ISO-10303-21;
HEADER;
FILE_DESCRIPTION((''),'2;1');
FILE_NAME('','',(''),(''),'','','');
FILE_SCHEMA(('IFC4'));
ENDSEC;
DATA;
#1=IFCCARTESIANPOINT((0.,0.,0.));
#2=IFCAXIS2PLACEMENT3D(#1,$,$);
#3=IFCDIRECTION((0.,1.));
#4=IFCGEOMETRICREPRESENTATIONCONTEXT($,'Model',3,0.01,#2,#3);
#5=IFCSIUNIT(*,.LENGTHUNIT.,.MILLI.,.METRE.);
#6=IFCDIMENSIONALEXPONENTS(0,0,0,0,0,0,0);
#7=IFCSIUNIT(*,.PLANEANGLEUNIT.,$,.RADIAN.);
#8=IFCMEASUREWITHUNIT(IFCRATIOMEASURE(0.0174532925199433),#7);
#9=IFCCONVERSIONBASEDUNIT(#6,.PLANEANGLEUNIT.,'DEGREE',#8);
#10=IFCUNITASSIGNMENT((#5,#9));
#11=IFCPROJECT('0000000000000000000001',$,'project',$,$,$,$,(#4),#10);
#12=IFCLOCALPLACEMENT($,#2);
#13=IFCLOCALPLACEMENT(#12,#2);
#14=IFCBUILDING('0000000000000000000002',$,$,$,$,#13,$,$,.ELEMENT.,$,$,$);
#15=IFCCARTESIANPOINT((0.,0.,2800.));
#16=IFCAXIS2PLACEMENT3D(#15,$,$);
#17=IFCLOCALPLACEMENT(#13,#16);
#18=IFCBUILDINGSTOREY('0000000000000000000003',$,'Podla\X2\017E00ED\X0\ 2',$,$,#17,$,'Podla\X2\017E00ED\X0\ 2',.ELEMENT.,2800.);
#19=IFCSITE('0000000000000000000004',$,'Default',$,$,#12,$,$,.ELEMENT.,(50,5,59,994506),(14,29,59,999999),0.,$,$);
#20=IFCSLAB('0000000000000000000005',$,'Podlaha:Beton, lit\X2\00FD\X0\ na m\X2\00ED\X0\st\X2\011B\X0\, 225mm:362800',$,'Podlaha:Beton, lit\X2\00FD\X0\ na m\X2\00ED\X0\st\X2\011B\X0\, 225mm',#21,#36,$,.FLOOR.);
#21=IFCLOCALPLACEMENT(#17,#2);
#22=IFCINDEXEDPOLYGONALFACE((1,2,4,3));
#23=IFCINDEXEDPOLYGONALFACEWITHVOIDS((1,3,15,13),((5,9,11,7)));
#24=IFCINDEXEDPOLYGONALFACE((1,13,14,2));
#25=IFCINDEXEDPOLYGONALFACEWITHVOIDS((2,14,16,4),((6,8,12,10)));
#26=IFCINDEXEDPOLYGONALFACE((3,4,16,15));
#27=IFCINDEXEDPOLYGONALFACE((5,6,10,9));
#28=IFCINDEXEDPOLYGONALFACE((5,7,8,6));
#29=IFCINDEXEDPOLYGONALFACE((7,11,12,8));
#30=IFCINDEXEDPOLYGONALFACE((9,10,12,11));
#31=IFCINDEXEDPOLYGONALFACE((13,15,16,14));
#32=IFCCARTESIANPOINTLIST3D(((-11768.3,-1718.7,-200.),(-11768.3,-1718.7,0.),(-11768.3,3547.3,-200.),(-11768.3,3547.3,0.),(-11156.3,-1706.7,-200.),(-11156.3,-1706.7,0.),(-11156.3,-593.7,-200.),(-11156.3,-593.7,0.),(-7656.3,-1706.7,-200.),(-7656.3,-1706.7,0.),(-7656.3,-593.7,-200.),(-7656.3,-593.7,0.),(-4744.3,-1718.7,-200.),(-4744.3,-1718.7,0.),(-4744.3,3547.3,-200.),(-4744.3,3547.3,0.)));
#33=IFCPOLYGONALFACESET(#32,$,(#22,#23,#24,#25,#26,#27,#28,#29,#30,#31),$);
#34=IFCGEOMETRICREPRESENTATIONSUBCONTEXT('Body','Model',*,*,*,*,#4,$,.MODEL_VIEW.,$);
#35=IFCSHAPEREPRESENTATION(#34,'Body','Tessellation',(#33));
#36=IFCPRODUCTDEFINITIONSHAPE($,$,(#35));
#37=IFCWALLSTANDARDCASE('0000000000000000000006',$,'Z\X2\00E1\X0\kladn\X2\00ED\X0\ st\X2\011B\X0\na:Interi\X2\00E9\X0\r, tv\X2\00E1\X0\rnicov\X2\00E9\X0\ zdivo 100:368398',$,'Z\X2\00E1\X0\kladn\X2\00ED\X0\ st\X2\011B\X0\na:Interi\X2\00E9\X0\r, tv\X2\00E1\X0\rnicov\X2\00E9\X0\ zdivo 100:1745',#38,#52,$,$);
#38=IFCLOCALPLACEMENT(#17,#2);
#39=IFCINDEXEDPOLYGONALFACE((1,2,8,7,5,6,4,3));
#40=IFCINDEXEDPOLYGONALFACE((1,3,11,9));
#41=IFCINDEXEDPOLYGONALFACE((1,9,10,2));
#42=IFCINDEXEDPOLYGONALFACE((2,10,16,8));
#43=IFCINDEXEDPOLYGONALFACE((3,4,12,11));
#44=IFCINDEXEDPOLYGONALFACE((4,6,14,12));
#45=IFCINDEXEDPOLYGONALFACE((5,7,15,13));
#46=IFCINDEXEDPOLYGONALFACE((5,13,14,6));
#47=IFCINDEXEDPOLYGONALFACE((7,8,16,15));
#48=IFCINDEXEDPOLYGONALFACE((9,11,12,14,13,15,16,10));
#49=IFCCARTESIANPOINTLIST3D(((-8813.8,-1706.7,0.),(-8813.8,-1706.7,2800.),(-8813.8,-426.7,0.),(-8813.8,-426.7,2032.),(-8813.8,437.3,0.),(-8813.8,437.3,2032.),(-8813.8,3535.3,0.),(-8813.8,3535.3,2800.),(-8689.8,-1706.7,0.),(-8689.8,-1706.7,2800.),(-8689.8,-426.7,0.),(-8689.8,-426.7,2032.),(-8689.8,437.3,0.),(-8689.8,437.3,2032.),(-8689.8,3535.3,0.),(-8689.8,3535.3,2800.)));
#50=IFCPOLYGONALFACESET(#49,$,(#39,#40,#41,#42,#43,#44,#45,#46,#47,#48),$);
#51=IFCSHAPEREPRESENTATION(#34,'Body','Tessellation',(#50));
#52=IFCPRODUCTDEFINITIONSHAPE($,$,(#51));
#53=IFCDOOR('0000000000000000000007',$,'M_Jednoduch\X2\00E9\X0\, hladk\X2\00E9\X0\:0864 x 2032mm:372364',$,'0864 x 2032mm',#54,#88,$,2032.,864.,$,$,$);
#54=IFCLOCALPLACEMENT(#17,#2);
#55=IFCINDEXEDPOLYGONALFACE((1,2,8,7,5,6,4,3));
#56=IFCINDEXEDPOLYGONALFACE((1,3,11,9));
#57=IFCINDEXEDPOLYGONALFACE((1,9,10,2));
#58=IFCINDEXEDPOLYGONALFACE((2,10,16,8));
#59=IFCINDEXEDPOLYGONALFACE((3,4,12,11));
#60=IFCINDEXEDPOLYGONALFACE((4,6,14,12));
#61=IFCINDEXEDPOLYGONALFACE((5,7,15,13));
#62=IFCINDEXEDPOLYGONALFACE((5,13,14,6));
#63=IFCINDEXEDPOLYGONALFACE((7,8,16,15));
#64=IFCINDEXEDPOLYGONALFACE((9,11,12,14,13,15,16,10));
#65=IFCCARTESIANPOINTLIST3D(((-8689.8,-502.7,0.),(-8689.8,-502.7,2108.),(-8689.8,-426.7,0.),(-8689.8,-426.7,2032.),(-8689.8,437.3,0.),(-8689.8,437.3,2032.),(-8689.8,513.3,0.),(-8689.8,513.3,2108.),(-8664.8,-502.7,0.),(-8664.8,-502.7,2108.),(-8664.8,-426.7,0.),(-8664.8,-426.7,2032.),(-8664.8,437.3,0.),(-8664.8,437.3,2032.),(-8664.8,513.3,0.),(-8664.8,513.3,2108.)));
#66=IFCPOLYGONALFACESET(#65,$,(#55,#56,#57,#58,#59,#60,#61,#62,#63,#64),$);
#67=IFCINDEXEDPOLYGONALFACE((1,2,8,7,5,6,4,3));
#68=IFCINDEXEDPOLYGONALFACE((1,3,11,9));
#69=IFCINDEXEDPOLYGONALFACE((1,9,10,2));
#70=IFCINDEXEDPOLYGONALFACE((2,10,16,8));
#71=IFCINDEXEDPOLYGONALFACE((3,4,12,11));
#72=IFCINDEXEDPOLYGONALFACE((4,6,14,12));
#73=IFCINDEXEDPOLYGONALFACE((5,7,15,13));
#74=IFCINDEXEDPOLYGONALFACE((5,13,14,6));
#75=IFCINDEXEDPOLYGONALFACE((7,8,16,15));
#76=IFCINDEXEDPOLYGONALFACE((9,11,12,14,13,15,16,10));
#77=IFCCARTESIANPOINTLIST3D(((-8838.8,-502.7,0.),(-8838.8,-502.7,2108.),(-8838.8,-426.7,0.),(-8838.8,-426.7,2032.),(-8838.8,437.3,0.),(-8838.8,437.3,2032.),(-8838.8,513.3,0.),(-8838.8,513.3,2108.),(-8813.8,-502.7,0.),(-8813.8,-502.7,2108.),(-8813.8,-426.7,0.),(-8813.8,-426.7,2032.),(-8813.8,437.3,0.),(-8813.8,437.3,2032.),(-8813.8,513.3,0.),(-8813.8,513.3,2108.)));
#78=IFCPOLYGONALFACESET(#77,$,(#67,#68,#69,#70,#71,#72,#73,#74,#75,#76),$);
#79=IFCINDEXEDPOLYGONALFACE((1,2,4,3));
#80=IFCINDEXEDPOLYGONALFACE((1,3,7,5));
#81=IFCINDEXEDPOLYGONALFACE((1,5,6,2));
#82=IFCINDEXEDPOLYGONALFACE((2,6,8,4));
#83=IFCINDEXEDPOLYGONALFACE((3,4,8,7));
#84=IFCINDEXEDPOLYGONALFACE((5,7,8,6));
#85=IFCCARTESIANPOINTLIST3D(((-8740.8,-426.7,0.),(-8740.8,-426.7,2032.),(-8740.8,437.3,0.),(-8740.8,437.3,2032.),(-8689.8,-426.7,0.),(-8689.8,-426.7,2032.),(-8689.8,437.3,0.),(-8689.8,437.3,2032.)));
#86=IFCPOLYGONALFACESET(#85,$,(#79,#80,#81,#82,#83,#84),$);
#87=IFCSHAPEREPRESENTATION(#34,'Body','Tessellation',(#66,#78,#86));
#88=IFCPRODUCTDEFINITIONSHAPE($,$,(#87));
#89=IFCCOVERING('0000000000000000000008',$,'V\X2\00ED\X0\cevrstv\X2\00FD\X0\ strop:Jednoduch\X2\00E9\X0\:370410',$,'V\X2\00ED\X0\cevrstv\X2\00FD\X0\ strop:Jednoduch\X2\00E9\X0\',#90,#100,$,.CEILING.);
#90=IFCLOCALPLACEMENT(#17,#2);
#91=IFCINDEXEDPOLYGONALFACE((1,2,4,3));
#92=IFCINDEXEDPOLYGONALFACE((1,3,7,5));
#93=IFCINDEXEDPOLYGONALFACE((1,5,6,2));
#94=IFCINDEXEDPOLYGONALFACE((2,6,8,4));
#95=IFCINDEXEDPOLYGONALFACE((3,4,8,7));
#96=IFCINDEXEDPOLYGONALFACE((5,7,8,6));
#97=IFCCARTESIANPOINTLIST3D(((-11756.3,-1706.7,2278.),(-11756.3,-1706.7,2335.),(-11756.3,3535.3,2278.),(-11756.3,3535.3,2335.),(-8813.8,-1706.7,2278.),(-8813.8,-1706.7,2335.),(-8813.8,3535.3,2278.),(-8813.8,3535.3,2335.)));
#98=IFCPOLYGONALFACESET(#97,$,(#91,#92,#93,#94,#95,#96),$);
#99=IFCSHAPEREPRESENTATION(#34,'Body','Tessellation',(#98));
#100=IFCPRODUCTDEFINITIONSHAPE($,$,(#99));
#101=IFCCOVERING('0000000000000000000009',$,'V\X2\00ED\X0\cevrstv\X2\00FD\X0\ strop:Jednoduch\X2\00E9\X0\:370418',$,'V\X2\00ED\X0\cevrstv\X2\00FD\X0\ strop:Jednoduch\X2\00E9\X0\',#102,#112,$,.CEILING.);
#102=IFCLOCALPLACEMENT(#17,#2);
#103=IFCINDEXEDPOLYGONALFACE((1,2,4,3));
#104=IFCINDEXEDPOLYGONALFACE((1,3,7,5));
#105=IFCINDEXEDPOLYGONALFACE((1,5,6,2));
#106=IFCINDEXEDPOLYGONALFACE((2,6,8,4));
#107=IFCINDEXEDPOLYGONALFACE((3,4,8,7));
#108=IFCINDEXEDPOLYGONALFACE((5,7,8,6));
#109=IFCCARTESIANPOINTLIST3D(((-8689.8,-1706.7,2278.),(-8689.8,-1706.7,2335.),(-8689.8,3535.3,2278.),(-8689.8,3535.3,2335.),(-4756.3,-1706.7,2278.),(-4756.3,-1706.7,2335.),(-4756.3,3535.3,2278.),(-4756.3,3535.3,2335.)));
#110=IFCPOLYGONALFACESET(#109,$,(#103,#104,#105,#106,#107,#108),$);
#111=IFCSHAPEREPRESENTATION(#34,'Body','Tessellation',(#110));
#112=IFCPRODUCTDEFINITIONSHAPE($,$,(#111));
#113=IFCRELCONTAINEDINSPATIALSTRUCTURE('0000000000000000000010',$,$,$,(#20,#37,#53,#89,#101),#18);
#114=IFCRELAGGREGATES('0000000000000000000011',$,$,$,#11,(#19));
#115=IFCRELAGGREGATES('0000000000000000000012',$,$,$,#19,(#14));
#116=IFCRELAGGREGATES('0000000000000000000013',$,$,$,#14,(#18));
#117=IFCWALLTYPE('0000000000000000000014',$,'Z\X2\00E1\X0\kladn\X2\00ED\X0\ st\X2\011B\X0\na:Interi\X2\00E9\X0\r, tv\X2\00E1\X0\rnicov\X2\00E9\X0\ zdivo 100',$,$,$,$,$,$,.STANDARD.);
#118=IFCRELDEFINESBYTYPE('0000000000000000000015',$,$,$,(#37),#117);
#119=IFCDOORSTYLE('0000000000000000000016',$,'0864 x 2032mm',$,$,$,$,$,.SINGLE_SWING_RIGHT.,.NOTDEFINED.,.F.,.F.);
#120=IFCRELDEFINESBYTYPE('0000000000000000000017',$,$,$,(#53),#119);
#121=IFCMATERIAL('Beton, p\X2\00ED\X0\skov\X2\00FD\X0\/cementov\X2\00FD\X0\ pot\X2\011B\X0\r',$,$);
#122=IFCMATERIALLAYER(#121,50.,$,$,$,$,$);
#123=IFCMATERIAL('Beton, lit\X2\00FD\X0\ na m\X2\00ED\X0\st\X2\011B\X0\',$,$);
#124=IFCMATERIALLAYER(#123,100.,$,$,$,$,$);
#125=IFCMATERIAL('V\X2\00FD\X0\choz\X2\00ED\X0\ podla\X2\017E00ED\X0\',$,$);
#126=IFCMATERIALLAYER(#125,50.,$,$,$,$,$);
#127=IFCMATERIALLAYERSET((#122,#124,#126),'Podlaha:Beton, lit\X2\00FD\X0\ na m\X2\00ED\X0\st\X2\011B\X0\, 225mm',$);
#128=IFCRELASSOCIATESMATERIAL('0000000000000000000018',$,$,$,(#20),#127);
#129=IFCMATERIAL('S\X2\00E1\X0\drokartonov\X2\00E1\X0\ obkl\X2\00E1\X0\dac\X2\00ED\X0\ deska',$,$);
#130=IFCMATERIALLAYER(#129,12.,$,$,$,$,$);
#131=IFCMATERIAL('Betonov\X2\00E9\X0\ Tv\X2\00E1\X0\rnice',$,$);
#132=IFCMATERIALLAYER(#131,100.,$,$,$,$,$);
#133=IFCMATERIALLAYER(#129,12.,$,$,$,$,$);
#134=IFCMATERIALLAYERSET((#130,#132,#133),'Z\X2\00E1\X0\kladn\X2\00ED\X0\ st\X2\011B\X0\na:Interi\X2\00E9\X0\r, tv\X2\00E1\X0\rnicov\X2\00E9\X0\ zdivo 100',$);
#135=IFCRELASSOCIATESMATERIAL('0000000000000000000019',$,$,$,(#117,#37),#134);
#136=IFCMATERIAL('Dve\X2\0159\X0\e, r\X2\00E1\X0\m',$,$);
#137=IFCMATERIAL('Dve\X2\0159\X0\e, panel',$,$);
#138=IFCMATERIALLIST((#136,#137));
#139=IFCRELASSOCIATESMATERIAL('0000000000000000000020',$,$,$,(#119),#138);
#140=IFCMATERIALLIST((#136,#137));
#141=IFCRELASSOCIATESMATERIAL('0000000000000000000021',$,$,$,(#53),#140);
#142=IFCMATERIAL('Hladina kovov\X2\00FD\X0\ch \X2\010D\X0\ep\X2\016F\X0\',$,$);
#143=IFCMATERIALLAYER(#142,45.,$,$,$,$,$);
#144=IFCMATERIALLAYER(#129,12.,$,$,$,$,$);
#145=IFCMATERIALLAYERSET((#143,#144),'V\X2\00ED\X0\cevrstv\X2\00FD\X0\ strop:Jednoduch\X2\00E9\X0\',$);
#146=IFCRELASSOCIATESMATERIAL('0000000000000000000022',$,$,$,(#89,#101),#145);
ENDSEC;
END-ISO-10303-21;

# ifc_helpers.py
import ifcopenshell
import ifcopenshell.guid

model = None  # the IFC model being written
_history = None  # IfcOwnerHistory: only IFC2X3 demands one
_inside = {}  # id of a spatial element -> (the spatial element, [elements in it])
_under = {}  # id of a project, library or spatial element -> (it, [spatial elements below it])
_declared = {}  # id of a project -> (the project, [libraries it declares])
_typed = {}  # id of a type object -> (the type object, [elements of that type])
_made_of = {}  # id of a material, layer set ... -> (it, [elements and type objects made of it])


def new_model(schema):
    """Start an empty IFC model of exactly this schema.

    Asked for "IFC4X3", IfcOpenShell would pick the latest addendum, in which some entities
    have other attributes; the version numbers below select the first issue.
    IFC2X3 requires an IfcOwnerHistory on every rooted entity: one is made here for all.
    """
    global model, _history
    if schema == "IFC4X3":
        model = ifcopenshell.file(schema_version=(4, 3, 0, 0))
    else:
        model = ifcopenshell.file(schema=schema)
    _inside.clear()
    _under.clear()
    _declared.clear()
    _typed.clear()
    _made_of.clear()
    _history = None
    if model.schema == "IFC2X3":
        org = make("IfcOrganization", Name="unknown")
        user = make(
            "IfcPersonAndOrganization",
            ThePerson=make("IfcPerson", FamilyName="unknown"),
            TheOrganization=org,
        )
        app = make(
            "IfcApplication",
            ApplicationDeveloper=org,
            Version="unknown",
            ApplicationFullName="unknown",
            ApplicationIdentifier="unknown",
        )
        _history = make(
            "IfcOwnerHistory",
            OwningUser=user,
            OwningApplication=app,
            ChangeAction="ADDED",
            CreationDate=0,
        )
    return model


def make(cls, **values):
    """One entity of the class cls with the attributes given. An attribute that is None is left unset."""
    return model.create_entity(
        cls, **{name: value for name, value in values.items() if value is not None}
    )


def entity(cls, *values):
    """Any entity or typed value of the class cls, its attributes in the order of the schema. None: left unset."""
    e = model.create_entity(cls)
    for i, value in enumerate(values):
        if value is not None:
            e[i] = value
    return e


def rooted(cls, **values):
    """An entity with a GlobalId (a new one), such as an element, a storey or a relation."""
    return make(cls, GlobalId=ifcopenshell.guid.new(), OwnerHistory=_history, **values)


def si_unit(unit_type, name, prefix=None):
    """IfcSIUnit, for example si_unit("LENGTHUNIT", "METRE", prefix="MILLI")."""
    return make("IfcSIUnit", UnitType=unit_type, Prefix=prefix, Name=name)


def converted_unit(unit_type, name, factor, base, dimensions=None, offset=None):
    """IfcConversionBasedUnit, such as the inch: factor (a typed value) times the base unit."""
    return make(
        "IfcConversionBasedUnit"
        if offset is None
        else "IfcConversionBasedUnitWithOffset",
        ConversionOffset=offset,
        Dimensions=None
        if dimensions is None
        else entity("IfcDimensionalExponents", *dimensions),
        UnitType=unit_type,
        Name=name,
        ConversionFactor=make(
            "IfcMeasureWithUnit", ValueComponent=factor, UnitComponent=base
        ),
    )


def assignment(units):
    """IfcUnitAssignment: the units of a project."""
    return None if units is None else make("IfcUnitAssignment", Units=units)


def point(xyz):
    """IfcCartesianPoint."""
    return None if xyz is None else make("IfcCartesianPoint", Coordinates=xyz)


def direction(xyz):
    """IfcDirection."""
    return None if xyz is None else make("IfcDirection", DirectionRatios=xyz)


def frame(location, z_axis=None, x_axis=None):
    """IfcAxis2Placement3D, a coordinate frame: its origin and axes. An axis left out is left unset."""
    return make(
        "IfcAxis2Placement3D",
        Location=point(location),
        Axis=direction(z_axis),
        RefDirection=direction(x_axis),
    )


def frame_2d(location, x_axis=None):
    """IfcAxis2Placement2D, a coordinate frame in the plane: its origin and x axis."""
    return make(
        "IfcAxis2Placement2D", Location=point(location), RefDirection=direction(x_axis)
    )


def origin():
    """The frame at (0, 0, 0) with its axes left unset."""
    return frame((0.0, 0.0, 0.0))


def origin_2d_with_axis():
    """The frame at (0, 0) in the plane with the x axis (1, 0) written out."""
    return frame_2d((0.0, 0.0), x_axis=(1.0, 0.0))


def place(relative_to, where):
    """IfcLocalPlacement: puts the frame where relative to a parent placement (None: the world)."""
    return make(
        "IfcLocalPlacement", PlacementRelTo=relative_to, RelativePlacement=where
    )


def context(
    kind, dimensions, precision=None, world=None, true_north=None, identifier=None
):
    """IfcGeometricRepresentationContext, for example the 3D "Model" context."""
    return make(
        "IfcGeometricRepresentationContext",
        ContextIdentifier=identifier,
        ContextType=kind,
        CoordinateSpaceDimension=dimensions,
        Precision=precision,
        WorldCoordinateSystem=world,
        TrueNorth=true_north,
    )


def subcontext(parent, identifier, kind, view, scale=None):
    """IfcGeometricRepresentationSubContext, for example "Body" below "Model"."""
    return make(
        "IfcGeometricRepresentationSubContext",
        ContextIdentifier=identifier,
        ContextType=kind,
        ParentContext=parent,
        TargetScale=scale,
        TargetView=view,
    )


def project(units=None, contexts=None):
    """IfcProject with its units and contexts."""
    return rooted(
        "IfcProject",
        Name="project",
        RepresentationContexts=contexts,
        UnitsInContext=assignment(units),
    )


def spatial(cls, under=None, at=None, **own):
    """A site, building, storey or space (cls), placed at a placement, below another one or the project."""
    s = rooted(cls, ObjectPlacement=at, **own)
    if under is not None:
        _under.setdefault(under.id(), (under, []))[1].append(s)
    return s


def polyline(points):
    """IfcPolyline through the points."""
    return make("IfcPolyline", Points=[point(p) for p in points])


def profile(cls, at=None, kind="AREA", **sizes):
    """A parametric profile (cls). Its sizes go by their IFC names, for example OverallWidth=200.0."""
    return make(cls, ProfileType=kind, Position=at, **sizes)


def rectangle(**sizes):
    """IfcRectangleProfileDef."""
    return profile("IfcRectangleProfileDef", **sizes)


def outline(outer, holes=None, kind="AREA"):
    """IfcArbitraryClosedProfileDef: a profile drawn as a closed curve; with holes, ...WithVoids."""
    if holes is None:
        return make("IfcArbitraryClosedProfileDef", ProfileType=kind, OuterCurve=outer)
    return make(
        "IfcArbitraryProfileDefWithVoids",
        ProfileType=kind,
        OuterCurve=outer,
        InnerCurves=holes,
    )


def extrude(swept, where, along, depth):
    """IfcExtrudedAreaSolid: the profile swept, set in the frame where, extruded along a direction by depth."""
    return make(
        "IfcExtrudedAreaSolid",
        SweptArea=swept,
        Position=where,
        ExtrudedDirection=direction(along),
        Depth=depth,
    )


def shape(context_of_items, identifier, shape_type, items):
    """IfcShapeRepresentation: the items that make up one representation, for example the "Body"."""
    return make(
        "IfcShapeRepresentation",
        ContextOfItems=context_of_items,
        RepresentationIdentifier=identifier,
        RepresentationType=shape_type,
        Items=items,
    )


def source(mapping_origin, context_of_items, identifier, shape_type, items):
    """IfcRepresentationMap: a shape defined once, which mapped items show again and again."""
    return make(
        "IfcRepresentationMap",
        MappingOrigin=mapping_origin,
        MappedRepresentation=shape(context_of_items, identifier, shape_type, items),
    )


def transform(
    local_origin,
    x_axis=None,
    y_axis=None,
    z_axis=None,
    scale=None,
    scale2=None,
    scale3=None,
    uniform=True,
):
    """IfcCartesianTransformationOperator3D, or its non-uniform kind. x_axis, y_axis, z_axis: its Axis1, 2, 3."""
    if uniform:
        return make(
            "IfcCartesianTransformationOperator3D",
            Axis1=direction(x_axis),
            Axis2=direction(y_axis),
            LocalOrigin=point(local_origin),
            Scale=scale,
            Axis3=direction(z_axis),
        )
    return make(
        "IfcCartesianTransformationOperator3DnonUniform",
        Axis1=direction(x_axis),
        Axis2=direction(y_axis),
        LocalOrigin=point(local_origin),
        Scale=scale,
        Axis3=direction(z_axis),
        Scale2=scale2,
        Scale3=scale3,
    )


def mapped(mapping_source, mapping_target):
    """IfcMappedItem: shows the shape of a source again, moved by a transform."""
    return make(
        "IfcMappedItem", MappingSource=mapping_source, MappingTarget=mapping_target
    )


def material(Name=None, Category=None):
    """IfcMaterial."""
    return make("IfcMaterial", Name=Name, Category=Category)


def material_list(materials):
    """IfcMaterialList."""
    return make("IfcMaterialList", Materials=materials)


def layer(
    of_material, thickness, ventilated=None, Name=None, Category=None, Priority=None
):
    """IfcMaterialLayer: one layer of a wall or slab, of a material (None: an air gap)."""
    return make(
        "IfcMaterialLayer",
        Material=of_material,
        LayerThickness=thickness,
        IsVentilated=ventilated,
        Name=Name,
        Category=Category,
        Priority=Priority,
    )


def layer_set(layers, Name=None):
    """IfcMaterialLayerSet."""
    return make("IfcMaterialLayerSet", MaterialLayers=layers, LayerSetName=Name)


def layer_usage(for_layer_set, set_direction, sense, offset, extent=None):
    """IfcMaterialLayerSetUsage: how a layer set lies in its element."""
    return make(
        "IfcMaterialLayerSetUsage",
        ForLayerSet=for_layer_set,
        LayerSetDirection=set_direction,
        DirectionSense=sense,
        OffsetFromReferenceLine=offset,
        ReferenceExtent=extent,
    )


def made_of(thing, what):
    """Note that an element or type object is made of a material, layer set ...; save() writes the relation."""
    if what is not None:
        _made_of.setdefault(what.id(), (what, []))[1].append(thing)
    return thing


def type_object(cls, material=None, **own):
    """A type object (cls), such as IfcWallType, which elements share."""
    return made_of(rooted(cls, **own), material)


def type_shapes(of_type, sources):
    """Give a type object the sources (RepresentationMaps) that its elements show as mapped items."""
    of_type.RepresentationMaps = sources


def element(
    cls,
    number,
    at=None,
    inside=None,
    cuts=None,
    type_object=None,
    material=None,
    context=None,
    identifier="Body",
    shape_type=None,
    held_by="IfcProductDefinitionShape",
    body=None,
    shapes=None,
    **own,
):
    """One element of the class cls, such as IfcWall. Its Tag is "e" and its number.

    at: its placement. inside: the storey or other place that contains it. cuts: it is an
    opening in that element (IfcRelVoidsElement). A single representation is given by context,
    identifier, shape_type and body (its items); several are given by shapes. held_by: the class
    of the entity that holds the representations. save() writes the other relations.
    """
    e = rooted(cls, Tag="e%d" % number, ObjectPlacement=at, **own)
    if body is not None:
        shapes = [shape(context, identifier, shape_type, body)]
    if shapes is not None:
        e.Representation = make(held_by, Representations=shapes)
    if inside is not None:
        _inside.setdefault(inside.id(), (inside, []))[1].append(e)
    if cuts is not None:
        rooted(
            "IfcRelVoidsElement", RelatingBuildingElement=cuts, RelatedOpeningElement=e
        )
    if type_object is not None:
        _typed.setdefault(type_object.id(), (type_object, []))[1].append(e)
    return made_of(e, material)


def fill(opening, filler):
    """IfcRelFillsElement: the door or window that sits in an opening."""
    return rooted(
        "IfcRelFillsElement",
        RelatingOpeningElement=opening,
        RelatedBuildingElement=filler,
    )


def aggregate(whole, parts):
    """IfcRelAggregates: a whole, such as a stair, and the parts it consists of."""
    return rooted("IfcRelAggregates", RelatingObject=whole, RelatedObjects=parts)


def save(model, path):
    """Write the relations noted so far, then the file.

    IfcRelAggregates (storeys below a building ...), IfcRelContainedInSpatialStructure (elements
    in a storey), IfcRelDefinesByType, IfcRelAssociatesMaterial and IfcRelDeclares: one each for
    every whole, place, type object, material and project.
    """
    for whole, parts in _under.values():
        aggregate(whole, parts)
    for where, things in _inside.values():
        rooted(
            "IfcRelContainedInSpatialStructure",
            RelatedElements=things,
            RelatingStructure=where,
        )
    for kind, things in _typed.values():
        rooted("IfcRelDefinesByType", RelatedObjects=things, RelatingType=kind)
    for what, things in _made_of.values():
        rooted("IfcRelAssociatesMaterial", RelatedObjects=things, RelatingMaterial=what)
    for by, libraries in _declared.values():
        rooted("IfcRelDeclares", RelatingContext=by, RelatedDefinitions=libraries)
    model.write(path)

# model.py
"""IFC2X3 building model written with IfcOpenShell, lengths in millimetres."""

from ifc_helpers import new_model, entity, si_unit, converted_unit, direction, frame, frame_2d, origin, origin_2d_with_axis, place, context, subcontext, project, spatial, polyline, rectangle, outline, extrude, source, transform, mapped, material, material_list, layer, layer_set, layer_usage, type_object, type_shapes, element, fill, save


model = new_model("IFC2X3")

# Units and contexts
model_context = context("Model", 3, precision=0.01, world=origin(), true_north=direction((0.0, 1.0)))
body_context = subcontext(model_context, "Body", "Model", "MODEL_VIEW")
ifc_project = project(units=[si_unit("LENGTHUNIT", "METRE", prefix="MILLI"), converted_unit("PLANEANGLEUNIT", "DEGREE", entity("IfcRatioMeasure", 0.0174532925199433), si_unit("PLANEANGLEUNIT", "RADIAN"), dimensions=[0, 0, 0, 0, 0, 0, 0])], contexts=[model_context])

# Site, building, storey
site_placement = place(None, origin())
site = spatial("IfcSite", under=ifc_project, at=site_placement, Name="Default", CompositionType="ELEMENT", RefLatitude=(50, 5, 59, 994506), RefLongitude=(14, 29, 59, 999999), RefElevation=0.0)
building_placement = place(site_placement, origin())
building = spatial("IfcBuilding", under=site, at=building_placement, CompositionType="ELEMENT")
storey_placement = place(building_placement, frame((0.0, 0.0, 2800.0)))
storey = spatial("IfcBuildingStorey", under=building, at=storey_placement, Name="Podlaží 2", LongName="Podlaží 2", CompositionType="ELEMENT", Elevation=2800.0)

# Slab, opening
ifc_material_1 = material(Name="Beton, pískový/cementový potěr")
ifc_layer_1 = layer(ifc_material_1, 50.0)
ifc_material_2 = material(Name="Beton, litý na místě")
ifc_layer_2 = layer(ifc_material_2, 100.0)
ifc_material_3 = material(Name="Výchozí podlaží")
ifc_layer_3 = layer(ifc_material_3, 50.0)
ifc_layer_set_1 = layer_set([ifc_layer_1, ifc_layer_2, ifc_layer_3], Name="Podlaha:Beton, litý na místě, 225mm")
ifc_layer_usage_1 = layer_usage(ifc_layer_set_1, "AXIS3", "POSITIVE", 0.0)
slab_placement = place(storey_placement, frame((-11768.3, -1718.7, -200.0)))
slab = element("IfcSlab", 1, at=slab_placement, inside=storey, material=ifc_layer_usage_1, Name="Podlaha:Beton, litý na místě, 225mm:362800", ObjectType="Podlaha:Beton, litý na místě, 225mm", PredefinedType="FLOOR", context=body_context, shape_type="SweptSolid", body=[
    extrude(rectangle(XDim=7024.0, YDim=5266.0, at=frame_2d((0.0, 0.0), x_axis=(-1.0, 0.0))), frame((3512.0, 2633.0, 200.0), z_axis=(0.0, 0.0, -1.0), x_axis=(-1.0, 0.0, 0.0)), (0.0, 0.0, 1.0), 200.0),
])
opening_1_placement = place(slab_placement, frame((2362.0, 568.5, 200.0)))
element("IfcOpeningElement", 2, at=opening_1_placement, cuts=slab, ObjectType="Opening", context=body_context, shape_type="SweptSolid", body=[
    extrude(rectangle(XDim=1113.0, YDim=3500.0, at=origin_2d_with_axis()), frame((0.0, 0.0, 0.0), z_axis=(0.0, 0.0, -1.0), x_axis=(0.0, -1.0, 0.0)), (0.0, 0.0, 1.0), 200.0),
])

# Wall, opening, door
ifc_material_4 = material(Name="Sádrokartonová obkládací deska")
ifc_layer_4 = layer(ifc_material_4, 12.0)
ifc_material_5 = material(Name="Betonové Tvárnice")
ifc_layer_5 = layer(ifc_material_5, 100.0)
ifc_layer_6 = layer(ifc_material_4, 12.0)
ifc_layer_set_2 = layer_set([ifc_layer_4, ifc_layer_5, ifc_layer_6], Name="Základní stěna:Interiér, tvárnicové zdivo 100")
ifc_layer_usage_2 = layer_usage(ifc_layer_set_2, "AXIS2", "NEGATIVE", 62.0)
wall_type = type_object("IfcWallType", Name="Základní stěna:Interiér, tvárnicové zdivo 100", PredefinedType="STANDARD", material=ifc_layer_set_2)
wall_placement = place(storey_placement, frame((-8751.8, 3535.3, 0.0), z_axis=(0.0, 0.0, 1.0), x_axis=(0.0, -1.0, 0.0)))
wall = element("IfcWallStandardCase", 3, at=wall_placement, inside=storey, type_object=wall_type, material=ifc_layer_usage_2, Name="Základní stěna:Interiér, tvárnicové zdivo 100:368398", ObjectType="Základní stěna:Interiér, tvárnicové zdivo 100:1745", context=body_context, shape_type="SweptSolid", body=[
    extrude(rectangle(XDim=5242.0, YDim=124.0, at=frame_2d((2621.0, 0.0), x_axis=(-1.0, 0.0))), origin(), (0.0, 0.0, 1.0), 2800.0),
])
opening_2_placement = place(wall_placement, frame((3098.0, -62.0, 0.0)))
opening_2 = element("IfcOpeningElement", 4, at=opening_2_placement, cuts=wall, ObjectType="Opening", context=body_context, shape_type="SweptSolid", body=[
    extrude(rectangle(XDim=864.0, YDim=2032.0, at=frame_2d((1016.0, 432.0), x_axis=(0.0, 1.0))), frame((0.0, 0.0, 0.0), z_axis=(0.0, 1.0, 0.0), x_axis=(0.0, 0.0, 1.0)), (0.0, 0.0, 1.0), 124.0),
])
ifc_material_6 = material(Name="Dveře, rám")
ifc_material_7 = material(Name="Dveře, panel")
ifc_material_list_1 = material_list([ifc_material_6, ifc_material_7])
ifc_material_list_2 = material_list([ifc_material_6, ifc_material_7])
door_style = type_object("IfcDoorStyle", Name="0864 x 2032mm", ConstructionType="NOTDEFINED", OperationType="SINGLE_SWING_RIGHT", ParameterTakesPrecedence=False, Sizeable=False, material=ifc_material_list_2)
shared_shape_1 = source(origin(), body_context, "Body", "SweptSolid", [
    extrude(outline(polyline([(-508.0, -1073.0), (508.0, -1073.0), (508.0, 1035.0), (432.0, 1035.0), (432.0, -997.0), (-432.0, -997.0), (-432.0, 1035.0), (-508.0, 1035.0), (-508.0, -1073.0)])), frame((432.0, 124.0, 1035.0), z_axis=(0.0, 1.0, 0.0), x_axis=(1.0, 0.0, 0.0)), (0.0, 0.0, 1.0), 25.0),
    extrude(outline(polyline([(-1073.0, -508.0), (1035.0, -508.0), (1035.0, -432.0), (-997.0, -432.0), (-997.0, 432.0), (1035.0, 432.0), (1035.0, 508.0), (-1073.0, 508.0), (-1073.0, -508.0)])), frame((432.0, -25.0, 1035.0), z_axis=(0.0, 1.0, 0.0), x_axis=(0.0, 0.0, -1.0)), (0.0, 0.0, 1.0), 25.0),
    extrude(rectangle(XDim=51.0, YDim=864.0, at=origin_2d_with_axis()), frame((432.0, 98.5, 0.0), z_axis=(0.0, 0.0, 1.0), x_axis=(0.0, 1.0, 0.0)), (0.0, 0.0, 1.0), 2032.0),
])
type_shapes(door_style, [shared_shape_1])
door_placement = place(opening_2_placement, origin())
door = element("IfcDoor", 5, at=door_placement, inside=storey, type_object=door_style, material=ifc_material_list_1, Name="M_Jednoduché, hladké:0864 x 2032mm:372364", ObjectType="0864 x 2032mm", OverallHeight=2032.0, OverallWidth=864.0, context=body_context, shape_type="MappedRepresentation", body=[
    mapped(shared_shape_1, transform((0.0, 0.0, 0.0), scale=1.0)),
])
fill(opening_2, door)

# Coverings
ifc_material_8 = material(Name="Hladina kovových čepů")
ifc_layer_7 = layer(ifc_material_8, 45.0)
ifc_layer_8 = layer(ifc_material_4, 12.0)
ifc_layer_set_3 = layer_set([ifc_layer_7, ifc_layer_8], Name="Vícevrstvý strop:Jednoduché")
ifc_layer_usage_3 = layer_usage(ifc_layer_set_3, "AXIS3", "NEGATIVE", 0.0)
covering_1_placement = place(storey_placement, origin())
element("IfcCovering", 6, at=covering_1_placement, inside=storey, material=ifc_layer_usage_3, Name="Vícevrstvý strop:Jednoduché:370410", ObjectType="Vícevrstvý strop:Jednoduché", PredefinedType="CEILING", context=body_context, shape_type="SweptSolid", body=[
    extrude(rectangle(XDim=5242.0, YDim=2942.5, at=frame_2d((0.0, 0.0), x_axis=(1.0, 0.0))), frame((-10285.0, 914.3, 2278.0), z_axis=(0.0, 0.0, 1.0), x_axis=(0.0, 1.0, 0.0)), (0.0, 0.0, 1.0), 57.0),
])
ifc_layer_usage_4 = layer_usage(ifc_layer_set_3, "AXIS3", "NEGATIVE", 0.0)
covering_2_placement = place(storey_placement, origin())
element("IfcCovering", 7, at=covering_2_placement, inside=storey, material=ifc_layer_usage_4, Name="Vícevrstvý strop:Jednoduché:370418", ObjectType="Vícevrstvý strop:Jednoduché", PredefinedType="CEILING", context=body_context, shape_type="SweptSolid", body=[
    extrude(rectangle(XDim=3933.5, YDim=5242.0, at=frame_2d((0.0, 0.0), x_axis=(1.0, 0.0))), frame((-6723.0, 914.3, 2278.0), z_axis=(0.0, 0.0, 1.0), x_axis=(-1.0, 0.0, 0.0)), (0.0, 0.0, 1.0), 57.0),
])

save(model, "model.ifc")
